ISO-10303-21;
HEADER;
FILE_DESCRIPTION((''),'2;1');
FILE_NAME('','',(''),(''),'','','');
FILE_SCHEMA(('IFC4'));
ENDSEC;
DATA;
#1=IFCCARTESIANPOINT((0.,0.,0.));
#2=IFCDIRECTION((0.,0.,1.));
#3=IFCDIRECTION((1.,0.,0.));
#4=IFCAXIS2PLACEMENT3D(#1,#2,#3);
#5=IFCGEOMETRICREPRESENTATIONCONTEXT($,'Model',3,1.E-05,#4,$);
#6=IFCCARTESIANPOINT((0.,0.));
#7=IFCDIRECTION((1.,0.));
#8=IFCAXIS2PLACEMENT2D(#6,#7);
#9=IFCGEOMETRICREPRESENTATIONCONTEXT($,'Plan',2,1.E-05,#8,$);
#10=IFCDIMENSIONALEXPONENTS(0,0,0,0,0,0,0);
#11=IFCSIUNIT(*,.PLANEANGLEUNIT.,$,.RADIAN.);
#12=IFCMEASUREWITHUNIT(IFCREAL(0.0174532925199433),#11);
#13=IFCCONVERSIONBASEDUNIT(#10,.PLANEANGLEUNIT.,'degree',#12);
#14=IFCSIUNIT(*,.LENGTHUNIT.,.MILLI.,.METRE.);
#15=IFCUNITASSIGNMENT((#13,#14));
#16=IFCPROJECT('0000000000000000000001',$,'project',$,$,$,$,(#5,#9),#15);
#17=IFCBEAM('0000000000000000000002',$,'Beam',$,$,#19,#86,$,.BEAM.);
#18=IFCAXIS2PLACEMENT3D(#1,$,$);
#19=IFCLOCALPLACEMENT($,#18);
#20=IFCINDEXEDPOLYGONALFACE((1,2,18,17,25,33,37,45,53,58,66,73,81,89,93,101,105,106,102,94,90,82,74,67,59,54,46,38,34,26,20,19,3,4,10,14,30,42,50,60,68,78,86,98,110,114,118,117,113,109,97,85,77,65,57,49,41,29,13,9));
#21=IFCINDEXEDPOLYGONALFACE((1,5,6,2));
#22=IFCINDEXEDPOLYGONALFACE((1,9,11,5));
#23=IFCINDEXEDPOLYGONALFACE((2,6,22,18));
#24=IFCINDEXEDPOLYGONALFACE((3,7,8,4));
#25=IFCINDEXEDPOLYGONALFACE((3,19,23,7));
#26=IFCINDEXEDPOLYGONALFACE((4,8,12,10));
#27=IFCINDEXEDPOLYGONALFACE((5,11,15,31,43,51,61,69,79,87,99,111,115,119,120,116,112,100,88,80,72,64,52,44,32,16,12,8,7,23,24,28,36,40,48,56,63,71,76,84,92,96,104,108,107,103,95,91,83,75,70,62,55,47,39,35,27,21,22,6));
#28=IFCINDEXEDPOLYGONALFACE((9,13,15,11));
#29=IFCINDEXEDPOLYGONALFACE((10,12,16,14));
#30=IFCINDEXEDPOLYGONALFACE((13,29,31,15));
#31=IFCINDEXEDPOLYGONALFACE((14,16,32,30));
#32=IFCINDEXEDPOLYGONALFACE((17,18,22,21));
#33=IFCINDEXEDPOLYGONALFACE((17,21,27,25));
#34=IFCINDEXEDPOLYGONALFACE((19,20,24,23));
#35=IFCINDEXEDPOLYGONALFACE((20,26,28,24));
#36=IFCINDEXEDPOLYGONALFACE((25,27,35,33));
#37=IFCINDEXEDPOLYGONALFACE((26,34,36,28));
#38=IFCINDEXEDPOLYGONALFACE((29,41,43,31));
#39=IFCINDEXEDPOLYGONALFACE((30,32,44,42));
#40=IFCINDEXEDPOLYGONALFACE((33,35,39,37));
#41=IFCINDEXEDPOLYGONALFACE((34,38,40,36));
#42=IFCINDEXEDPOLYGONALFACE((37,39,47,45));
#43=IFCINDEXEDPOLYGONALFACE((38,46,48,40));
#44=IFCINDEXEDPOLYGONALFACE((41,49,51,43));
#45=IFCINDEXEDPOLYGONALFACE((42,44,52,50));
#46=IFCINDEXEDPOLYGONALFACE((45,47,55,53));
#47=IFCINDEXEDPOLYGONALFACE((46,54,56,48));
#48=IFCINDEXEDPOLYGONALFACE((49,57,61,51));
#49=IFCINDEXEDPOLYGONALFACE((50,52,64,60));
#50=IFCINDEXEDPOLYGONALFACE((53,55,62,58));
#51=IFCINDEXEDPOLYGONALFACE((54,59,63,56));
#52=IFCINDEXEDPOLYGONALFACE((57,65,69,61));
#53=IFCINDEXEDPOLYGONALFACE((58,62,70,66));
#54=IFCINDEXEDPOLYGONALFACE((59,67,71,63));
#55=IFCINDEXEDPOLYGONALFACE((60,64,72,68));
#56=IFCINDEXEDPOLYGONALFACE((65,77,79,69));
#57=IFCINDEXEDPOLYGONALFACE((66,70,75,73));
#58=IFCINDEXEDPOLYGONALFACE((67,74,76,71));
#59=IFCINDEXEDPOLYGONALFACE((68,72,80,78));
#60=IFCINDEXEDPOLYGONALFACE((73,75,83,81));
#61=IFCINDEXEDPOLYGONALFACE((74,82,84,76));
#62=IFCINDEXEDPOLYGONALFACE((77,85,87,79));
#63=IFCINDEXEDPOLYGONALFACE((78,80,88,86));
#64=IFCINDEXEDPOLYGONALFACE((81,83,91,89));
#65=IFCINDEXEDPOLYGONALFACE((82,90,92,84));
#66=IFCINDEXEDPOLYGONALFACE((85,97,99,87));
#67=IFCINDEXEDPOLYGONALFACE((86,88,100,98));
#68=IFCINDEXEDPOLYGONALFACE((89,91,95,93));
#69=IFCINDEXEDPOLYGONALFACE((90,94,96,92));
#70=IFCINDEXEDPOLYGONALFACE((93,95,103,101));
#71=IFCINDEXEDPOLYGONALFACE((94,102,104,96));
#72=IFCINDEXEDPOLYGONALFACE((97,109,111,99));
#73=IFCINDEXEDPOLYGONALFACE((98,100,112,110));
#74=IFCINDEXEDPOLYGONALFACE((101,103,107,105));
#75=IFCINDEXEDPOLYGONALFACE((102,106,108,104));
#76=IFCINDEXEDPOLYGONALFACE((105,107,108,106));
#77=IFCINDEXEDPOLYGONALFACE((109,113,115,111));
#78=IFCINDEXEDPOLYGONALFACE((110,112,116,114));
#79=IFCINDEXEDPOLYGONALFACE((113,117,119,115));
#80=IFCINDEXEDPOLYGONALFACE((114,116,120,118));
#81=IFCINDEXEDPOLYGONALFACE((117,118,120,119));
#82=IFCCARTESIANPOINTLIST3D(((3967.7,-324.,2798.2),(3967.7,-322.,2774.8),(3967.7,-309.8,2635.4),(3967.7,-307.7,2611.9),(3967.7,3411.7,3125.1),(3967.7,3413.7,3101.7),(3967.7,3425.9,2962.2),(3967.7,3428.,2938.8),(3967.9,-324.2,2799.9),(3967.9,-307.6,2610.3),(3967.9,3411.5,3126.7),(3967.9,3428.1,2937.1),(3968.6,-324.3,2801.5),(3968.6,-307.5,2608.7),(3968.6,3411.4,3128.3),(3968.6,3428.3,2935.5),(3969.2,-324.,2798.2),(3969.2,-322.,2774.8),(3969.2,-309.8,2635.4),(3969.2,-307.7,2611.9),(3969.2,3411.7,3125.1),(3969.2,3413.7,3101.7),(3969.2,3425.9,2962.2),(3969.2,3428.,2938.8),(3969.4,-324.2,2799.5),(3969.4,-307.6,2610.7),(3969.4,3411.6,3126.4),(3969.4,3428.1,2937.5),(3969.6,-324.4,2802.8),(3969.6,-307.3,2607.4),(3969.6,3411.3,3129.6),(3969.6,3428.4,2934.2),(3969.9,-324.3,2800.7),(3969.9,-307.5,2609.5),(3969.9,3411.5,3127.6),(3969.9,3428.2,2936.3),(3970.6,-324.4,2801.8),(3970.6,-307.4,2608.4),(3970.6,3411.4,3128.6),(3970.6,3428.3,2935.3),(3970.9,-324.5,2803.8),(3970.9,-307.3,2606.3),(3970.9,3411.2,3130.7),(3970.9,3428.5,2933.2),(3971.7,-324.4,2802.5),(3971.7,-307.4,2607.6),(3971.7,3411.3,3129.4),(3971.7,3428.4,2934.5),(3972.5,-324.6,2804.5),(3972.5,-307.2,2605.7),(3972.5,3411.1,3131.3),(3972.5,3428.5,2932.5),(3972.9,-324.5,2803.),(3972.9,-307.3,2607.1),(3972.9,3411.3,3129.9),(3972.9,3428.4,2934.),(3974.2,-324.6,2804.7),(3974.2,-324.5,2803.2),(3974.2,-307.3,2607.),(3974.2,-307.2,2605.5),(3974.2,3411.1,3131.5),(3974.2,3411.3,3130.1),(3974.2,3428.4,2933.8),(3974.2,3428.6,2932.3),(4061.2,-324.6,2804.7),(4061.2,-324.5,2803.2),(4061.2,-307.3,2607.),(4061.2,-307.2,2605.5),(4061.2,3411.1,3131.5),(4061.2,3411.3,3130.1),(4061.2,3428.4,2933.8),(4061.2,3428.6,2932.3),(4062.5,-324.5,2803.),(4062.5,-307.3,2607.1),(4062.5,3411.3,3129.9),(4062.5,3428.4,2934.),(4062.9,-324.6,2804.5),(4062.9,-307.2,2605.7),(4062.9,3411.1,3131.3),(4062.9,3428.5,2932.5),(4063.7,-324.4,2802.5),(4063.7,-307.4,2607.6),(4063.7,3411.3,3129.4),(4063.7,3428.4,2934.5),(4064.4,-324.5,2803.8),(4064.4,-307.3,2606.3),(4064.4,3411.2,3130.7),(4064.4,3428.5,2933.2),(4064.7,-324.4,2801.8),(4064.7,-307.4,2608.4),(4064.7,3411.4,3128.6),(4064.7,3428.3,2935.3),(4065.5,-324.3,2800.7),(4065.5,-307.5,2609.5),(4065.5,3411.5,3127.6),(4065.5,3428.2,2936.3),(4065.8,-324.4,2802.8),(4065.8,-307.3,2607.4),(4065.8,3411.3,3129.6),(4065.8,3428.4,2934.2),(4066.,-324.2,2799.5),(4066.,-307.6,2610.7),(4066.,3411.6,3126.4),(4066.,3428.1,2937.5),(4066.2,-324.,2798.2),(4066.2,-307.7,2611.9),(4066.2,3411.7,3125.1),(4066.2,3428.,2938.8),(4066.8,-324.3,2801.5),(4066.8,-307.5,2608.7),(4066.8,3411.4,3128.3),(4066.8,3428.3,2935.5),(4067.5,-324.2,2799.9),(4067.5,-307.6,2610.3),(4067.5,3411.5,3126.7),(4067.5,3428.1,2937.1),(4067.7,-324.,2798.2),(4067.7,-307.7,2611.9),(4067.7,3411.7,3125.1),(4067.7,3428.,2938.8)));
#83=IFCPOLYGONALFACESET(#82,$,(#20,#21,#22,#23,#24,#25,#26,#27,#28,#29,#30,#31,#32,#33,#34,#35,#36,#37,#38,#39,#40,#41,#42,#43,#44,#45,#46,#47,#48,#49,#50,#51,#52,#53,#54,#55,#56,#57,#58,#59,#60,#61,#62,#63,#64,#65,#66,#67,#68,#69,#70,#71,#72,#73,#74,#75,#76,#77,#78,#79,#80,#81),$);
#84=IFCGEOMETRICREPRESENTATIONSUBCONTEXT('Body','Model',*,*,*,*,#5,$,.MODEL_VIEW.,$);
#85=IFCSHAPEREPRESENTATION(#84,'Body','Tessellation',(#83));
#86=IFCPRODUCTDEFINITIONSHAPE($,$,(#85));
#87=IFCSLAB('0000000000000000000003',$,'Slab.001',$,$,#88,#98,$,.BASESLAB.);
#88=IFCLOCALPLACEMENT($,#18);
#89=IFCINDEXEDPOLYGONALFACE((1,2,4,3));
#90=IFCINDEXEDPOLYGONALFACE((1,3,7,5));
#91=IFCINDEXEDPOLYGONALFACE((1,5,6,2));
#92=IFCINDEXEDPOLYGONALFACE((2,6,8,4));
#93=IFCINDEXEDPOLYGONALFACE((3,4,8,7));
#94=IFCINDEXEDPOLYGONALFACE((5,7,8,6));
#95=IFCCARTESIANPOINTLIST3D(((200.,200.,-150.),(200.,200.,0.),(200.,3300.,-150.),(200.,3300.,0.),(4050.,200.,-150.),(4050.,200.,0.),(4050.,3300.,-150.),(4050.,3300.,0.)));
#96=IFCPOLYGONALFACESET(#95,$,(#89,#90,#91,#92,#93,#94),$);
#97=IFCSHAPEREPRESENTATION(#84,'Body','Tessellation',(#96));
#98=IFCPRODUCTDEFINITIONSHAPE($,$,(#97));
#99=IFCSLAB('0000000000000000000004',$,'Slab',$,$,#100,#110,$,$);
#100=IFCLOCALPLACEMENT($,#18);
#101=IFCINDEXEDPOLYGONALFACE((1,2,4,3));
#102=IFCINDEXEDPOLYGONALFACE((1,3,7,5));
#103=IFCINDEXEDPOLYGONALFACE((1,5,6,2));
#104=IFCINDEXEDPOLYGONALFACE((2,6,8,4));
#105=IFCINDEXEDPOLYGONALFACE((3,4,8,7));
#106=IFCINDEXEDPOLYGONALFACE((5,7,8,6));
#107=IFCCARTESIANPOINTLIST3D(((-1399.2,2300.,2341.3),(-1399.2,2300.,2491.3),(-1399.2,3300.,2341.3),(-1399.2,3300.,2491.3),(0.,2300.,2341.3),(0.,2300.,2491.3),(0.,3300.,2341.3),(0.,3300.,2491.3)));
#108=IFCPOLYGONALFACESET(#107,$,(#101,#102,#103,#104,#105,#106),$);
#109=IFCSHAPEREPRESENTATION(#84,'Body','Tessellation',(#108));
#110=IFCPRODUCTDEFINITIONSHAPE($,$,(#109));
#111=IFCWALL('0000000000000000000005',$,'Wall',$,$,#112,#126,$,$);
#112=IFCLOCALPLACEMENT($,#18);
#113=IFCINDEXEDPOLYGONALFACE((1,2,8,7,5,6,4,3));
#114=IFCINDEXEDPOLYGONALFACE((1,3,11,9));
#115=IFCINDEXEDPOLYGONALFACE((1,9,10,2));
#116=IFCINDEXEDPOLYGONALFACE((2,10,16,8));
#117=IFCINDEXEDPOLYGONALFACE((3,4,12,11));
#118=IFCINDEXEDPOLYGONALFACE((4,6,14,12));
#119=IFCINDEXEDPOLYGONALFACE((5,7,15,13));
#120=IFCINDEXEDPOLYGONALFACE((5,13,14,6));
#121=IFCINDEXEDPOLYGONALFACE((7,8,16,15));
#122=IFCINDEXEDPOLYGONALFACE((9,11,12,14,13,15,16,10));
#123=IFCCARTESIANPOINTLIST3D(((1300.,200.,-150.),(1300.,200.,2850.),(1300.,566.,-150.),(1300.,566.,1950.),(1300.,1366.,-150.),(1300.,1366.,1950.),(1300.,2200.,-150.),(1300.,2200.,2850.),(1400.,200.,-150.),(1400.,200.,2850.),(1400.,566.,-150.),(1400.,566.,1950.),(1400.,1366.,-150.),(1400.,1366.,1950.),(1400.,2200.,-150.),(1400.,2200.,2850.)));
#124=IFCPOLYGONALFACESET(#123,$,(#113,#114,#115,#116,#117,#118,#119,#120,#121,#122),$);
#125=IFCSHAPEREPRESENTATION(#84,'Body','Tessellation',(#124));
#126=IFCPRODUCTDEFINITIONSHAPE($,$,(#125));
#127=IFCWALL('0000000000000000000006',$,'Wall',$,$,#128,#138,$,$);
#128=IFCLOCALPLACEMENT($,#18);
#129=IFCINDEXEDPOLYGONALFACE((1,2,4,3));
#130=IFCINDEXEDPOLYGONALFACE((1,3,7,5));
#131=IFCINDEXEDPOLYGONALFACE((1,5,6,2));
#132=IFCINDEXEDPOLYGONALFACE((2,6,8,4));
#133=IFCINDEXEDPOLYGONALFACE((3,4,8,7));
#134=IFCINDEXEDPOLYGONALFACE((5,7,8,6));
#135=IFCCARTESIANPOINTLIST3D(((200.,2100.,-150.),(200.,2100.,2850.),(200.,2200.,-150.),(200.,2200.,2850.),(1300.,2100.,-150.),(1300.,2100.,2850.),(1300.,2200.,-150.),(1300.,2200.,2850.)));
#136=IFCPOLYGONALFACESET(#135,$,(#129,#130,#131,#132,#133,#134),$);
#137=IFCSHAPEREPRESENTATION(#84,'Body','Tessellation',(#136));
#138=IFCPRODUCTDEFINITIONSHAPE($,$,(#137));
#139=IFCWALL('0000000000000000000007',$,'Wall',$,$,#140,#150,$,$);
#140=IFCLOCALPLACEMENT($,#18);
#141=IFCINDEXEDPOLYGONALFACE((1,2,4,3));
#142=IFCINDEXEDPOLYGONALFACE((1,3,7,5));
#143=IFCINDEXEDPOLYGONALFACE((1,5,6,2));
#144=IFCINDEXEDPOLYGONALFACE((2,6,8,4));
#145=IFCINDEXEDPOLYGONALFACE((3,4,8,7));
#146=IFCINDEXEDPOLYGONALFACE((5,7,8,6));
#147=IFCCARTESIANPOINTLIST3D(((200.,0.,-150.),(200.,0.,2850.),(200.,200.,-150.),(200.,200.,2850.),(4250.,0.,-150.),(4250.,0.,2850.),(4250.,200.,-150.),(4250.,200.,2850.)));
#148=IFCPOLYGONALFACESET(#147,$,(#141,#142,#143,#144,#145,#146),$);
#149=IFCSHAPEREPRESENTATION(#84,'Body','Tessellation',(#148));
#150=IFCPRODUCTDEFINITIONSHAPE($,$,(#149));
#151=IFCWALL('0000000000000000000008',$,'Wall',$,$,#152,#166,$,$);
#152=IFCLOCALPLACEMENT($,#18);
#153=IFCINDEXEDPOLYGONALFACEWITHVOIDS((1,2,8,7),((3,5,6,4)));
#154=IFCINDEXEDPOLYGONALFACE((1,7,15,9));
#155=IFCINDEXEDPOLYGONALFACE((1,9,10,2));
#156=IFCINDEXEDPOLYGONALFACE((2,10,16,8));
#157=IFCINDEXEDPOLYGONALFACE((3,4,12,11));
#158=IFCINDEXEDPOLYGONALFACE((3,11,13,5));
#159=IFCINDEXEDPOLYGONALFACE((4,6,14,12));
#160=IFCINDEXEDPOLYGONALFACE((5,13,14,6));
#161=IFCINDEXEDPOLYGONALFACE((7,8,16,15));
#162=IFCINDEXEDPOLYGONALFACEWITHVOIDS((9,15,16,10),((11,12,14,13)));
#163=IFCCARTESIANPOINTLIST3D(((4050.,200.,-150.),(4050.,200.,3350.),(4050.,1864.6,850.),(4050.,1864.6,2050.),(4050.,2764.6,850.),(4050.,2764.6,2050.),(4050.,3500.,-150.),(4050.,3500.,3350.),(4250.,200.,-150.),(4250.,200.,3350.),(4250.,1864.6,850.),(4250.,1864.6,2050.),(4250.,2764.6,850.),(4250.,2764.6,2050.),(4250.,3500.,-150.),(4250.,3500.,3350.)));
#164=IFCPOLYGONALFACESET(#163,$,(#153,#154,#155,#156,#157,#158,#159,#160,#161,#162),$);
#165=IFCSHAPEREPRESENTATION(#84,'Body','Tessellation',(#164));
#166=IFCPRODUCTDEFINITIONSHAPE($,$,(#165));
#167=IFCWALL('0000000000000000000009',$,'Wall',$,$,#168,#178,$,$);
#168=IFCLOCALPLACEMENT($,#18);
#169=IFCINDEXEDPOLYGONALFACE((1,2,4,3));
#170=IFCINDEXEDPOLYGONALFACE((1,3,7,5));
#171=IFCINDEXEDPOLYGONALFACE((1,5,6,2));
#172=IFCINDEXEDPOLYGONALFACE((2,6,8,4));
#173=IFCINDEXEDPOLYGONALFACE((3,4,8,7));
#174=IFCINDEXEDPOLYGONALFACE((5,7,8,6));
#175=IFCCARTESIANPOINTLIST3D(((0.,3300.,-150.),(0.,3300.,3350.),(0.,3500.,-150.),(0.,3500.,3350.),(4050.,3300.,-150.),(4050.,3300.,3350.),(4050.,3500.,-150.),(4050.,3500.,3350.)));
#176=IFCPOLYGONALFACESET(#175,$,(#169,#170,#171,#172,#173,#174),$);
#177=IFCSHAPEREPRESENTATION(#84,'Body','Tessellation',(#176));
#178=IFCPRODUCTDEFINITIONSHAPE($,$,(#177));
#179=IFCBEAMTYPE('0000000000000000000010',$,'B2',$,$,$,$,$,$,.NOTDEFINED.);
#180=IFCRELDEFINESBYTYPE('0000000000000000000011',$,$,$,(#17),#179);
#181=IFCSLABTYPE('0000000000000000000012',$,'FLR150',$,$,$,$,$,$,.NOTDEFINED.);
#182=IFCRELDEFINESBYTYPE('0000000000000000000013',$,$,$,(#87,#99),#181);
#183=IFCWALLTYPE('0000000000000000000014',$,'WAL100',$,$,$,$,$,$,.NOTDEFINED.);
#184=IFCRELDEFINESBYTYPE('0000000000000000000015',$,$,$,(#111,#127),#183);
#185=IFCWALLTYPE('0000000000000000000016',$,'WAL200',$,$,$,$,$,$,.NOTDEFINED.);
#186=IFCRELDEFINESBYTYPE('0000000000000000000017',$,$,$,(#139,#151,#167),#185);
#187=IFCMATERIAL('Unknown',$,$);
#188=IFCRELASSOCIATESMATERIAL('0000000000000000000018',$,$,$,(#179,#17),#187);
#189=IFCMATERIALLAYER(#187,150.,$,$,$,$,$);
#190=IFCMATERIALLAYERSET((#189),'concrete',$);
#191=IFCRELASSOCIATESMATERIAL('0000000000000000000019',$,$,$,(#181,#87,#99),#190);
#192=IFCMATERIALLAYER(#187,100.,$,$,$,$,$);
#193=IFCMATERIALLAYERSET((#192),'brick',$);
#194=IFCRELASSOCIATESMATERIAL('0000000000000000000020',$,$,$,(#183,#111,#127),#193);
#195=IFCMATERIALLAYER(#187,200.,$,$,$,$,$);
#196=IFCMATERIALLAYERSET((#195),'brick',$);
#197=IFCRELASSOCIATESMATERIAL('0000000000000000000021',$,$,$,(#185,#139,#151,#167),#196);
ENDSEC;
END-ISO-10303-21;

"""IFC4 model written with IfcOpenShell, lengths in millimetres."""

from ifc_helpers import new_model, entity, si_unit, converted_unit, frame, origin_with_axes, origin_2d_with_axis, place, context, subcontext, project, line, indexed_curve, c_section, outline, extrude, source, transform, mapped, material, layer, layer_set, layer_usage, material_profile, profile_set, profile_usage, type_object, element, save


model = new_model("IFC4")

# Units and contexts
model_context = context("Model", 3, precision=1e-05, world=origin_with_axes())
plan_context = context("Plan", 2, precision=1e-05, world=origin_2d_with_axis())
body_context = subcontext(model_context, "Body", "Model", "MODEL_VIEW")
ifc_project = project(units=[converted_unit("PLANEANGLEUNIT", "degree", entity("IfcReal", 0.0174532925199433), si_unit("PLANEANGLEUNIT", "RADIAN"), dimensions=[0, 0, 0, 0, 0, 0, 0]), si_unit("LENGTHUNIT", "METRE", prefix="MILLI")], contexts=[model_context, plan_context])

# Shared definitions
ifc_material = material(Name="Unknown")
placement = place(None, frame((0.0, 0.0, -150.0), z_axis=(0.0, 0.0, 1.0), x_axis=(1.0, 0.0, 0.0)))

# Beam
ifc_material_profile_1 = material_profile(ifc_material, c_section(Depth=200.0, Width=100.0, WallThickness=1.5, Girth=30.0, InternalFilletRadius=5.0))
ifc_profile_set_1 = profile_set([ifc_material_profile_1])
beam_type_1 = type_object("IfcBeamType", Name="B2", PredefinedType="NOTDEFINED", material=ifc_profile_set_1)
ifc_profile_usage_1 = profile_usage(ifc_profile_set_1, cardinal=5)
beam_1_placement = place(None, frame((4017.7, -315.9, 2705.1), z_axis=(0.0, 0.996195, 0.087155), x_axis=(-1.0, 0.0, 0.0)))
element("IfcBeam", 1, at=beam_1_placement, type_object=beam_type_1, material=ifc_profile_usage_1, Name="Beam", PredefinedType="BEAM", context=body_context, shape_type="SweptSolid", body=[
    extrude(c_section(Depth=200.0, Width=100.0, WallThickness=1.5, Girth=30.0, InternalFilletRadius=5.0), origin_with_axes(), (0.0, 0.0, 1.0), 3750.0),
])

# Slabs
ifc_layer_1 = layer(ifc_material, 150.0)
ifc_layer_set_1 = layer_set([ifc_layer_1], Name="concrete")
ifc_layer_usage_1 = layer_usage(ifc_layer_set_1, "AXIS3", "POSITIVE", 0.0)
slab_type_1 = type_object("IfcSlabType", Name="FLR150", PredefinedType="NOTDEFINED", material=ifc_layer_set_1)
slab_1_placement = place(placement, frame((4050.0, 200.0, 0.0), z_axis=(0.0, 0.0, 1.0), x_axis=(1.0, 0.0, 0.0)))
element("IfcSlab", 2, at=slab_1_placement, type_object=slab_type_1, material=ifc_layer_usage_1, Name="Slab.001", PredefinedType="BASESLAB", context=body_context, shape_type="SweptSolid", body=[
    extrude(outline(indexed_curve([(0.0, 3100.0), (0.0, 0.0), (-3850.0, 0.0), (-3850.0, 3100.0)], segments=[line(3, 2), line(2, 1), line(1, 4), line(4, 3)], self_intersect=False)), None, (0.0, 0.0, 1.0), 150.0),
])
ifc_layer_usage_2 = layer_usage(ifc_layer_set_1, "AXIS3", "POSITIVE", 0.0)
slab_2_placement = place(placement, frame((0.0, 3300.0, 2491.3), z_axis=(0.0, 0.0, 1.0), x_axis=(-1.0, 0.0, 0.0)))
element("IfcSlab", 3, at=slab_2_placement, type_object=slab_type_1, material=ifc_layer_usage_2, Name="Slab", context=body_context, shape_type="SweptSolid", body=[
    extrude(outline(indexed_curve([(0.0, 0.0), (1399.2, 0.0), (1399.2, 1000.0), (0.0, 1000.0)], segments=[line(4, 1), line(1, 2), line(2, 3), line(3, 4)], self_intersect=False)), None, (0.0, 0.0, 1.0), 150.0),
])

# Wall, opening
ifc_layer_2 = layer(ifc_material, 100.0)
ifc_layer_set_2 = layer_set([ifc_layer_2], Name="brick")
ifc_layer_usage_3 = layer_usage(ifc_layer_set_2, "AXIS2", "POSITIVE", 0.0)
wall_type_1 = type_object("IfcWallType", Name="WAL100", PredefinedType="NOTDEFINED", material=ifc_layer_set_2)
wall_1_placement = place(placement, frame((1400.0, 200.0, 0.0), z_axis=(0.0, 0.0, 1.0), x_axis=(0.000001, 1.0, 0.0)))
wall_1 = element("IfcWall", 4, at=wall_1_placement, type_object=wall_type_1, material=ifc_layer_usage_3, Name="Wall", context=body_context, shape_type="SweptSolid", body=[
    extrude(outline(indexed_curve([(0.0, 0.0), (0.0, 100.0), (2000.0, 100.0), (2000.0, 0.0), (0.0, 0.0)], self_intersect=False)), origin_with_axes(), (0.0, 0.0, 1.0), 3000.0),
])
shared_shape_1 = source(origin_with_axes(), body_context, "Body", "SweptSolid", [
    extrude(outline(indexed_curve([(0.0, 0.0), (800.0, 0.0), (800.0, 2100.0), (0.0, 2100.0)], segments=[line(1, 2, 3, 4, 1)])), frame((0.0, -600.0, 0.0), z_axis=(0.0, -1.0, 0.0), x_axis=(1.0, 0.0, 0.0)), (0.0, 0.0, -1.0), 1200.0),
])
opening_1_placement = place(wall_1_placement, frame((366.0, 100.0, 0.0), z_axis=(0.0, 0.0, 1.0), x_axis=(1.0, 0.0, 0.0)))
element("IfcOpeningElement", 5, at=opening_1_placement, cuts=wall_1, PredefinedType="OPENING", context=body_context, shape_type="MappedRepresentation", body=[
    mapped(shared_shape_1, transform((0.0, 0.0, 0.0), x_axis=(1.0, 0.0, 0.0), y_axis=(0.0, 1.0, 0.0), z_axis=(0.0, 0.0, 1.0), scale=1.0)),
])

# Walls
ifc_layer_usage_4 = layer_usage(ifc_layer_set_2, "AXIS2", "POSITIVE", 0.0)
wall_2_placement = place(placement, frame((200.0, 2100.0, 0.0), z_axis=(0.0, 0.0, 1.0), x_axis=(1.0, 0.0, 0.0)))
element("IfcWall", 6, at=wall_2_placement, type_object=wall_type_1, material=ifc_layer_usage_4, Name="Wall", context=body_context, shape_type="SweptSolid", body=[
    extrude(outline(indexed_curve([(0.0, 0.0), (0.0, 100.0), (1100.0, 100.0), (1100.0, 0.0), (0.0, 0.0)], self_intersect=False)), origin_with_axes(), (0.0, 0.0, 1.0), 3000.0),
])
ifc_layer_3 = layer(ifc_material, 200.0)
ifc_layer_set_3 = layer_set([ifc_layer_3], Name="brick")
ifc_layer_usage_5 = layer_usage(ifc_layer_set_3, "AXIS2", "POSITIVE", 0.0)
wall_type_2 = type_object("IfcWallType", Name="WAL200", PredefinedType="NOTDEFINED", material=ifc_layer_set_3)
wall_3_placement = place(placement, frame((200.0, 0.0, 0.0), z_axis=(0.0, 0.0, 1.0), x_axis=(1.0, 0.0, 0.0)))
element("IfcWall", 7, at=wall_3_placement, type_object=wall_type_2, material=ifc_layer_usage_5, Name="Wall", context=body_context, shape_type="SweptSolid", body=[
    extrude(outline(indexed_curve([(0.0, 0.0), (0.0, 200.0), (4050.0, 200.0), (4050.0, 0.0), (0.0, 0.0)], self_intersect=False)), origin_with_axes(), (0.0, 0.0, 1.0), 3000.0),
])

# Wall, opening
ifc_layer_usage_6 = layer_usage(ifc_layer_set_3, "AXIS2", "POSITIVE", 0.0)
wall_4_placement = place(placement, frame((4250.0, 200.0, 0.0), z_axis=(0.0, 0.0, 1.0), x_axis=(0.0, 1.0, 0.0)))
wall_4 = element("IfcWall", 8, at=wall_4_placement, type_object=wall_type_2, material=ifc_layer_usage_6, Name="Wall", context=body_context, shape_type="SweptSolid", body=[
    extrude(outline(indexed_curve([(0.0, 0.0), (0.0, 200.0), (3300.0, 200.0), (3300.0, 0.0), (0.0, 0.0)], self_intersect=False)), origin_with_axes(), (0.0, 0.0, 1.0), 3500.0),
])
shared_shape_2 = source(origin_with_axes(), body_context, "Body", "SweptSolid", [
    extrude(outline(indexed_curve([(0.0, 0.0), (900.0, 0.0), (900.0, 1200.0), (0.0, 1200.0)], segments=[line(1, 2, 3, 4, 1)])), frame((0.0, -600.0, 0.0), z_axis=(0.0, -1.0, 0.0), x_axis=(1.0, 0.0, 0.0)), (0.0, 0.0, -1.0), 1200.0),
])
opening_2_placement = place(wall_4_placement, frame((1664.6, 0.0, 1000.0), z_axis=(0.0, 0.0, 1.0), x_axis=(1.0, 0.0, 0.0)))
element("IfcOpeningElement", 9, at=opening_2_placement, cuts=wall_4, PredefinedType="OPENING", context=body_context, shape_type="MappedRepresentation", body=[
    mapped(shared_shape_2, transform((0.0, 0.0, 0.0), x_axis=(1.0, 0.0, 0.0), y_axis=(0.0, 1.0, 0.0), z_axis=(0.0, 0.0, 1.0), scale=1.0)),
])

# Wall
ifc_layer_usage_7 = layer_usage(ifc_layer_set_3, "AXIS2", "POSITIVE", 0.0)
wall_5_placement = place(placement, frame((4050.0, 3500.0, 0.0), z_axis=(0.0, 0.0, 1.0), x_axis=(-1.0, 0.0, 0.0)))
element("IfcWall", 10, at=wall_5_placement, type_object=wall_type_2, material=ifc_layer_usage_7, Name="Wall", context=body_context, shape_type="SweptSolid", body=[
    extrude(outline(indexed_curve([(0.0, 0.0), (0.0, 200.0), (4050.0, 200.0), (4050.0, 0.0), (0.0, 0.0)], self_intersect=False)), origin_with_axes(), (0.0, 0.0, 1.0), 3500.0),
])

save(model, "model.ifc")
